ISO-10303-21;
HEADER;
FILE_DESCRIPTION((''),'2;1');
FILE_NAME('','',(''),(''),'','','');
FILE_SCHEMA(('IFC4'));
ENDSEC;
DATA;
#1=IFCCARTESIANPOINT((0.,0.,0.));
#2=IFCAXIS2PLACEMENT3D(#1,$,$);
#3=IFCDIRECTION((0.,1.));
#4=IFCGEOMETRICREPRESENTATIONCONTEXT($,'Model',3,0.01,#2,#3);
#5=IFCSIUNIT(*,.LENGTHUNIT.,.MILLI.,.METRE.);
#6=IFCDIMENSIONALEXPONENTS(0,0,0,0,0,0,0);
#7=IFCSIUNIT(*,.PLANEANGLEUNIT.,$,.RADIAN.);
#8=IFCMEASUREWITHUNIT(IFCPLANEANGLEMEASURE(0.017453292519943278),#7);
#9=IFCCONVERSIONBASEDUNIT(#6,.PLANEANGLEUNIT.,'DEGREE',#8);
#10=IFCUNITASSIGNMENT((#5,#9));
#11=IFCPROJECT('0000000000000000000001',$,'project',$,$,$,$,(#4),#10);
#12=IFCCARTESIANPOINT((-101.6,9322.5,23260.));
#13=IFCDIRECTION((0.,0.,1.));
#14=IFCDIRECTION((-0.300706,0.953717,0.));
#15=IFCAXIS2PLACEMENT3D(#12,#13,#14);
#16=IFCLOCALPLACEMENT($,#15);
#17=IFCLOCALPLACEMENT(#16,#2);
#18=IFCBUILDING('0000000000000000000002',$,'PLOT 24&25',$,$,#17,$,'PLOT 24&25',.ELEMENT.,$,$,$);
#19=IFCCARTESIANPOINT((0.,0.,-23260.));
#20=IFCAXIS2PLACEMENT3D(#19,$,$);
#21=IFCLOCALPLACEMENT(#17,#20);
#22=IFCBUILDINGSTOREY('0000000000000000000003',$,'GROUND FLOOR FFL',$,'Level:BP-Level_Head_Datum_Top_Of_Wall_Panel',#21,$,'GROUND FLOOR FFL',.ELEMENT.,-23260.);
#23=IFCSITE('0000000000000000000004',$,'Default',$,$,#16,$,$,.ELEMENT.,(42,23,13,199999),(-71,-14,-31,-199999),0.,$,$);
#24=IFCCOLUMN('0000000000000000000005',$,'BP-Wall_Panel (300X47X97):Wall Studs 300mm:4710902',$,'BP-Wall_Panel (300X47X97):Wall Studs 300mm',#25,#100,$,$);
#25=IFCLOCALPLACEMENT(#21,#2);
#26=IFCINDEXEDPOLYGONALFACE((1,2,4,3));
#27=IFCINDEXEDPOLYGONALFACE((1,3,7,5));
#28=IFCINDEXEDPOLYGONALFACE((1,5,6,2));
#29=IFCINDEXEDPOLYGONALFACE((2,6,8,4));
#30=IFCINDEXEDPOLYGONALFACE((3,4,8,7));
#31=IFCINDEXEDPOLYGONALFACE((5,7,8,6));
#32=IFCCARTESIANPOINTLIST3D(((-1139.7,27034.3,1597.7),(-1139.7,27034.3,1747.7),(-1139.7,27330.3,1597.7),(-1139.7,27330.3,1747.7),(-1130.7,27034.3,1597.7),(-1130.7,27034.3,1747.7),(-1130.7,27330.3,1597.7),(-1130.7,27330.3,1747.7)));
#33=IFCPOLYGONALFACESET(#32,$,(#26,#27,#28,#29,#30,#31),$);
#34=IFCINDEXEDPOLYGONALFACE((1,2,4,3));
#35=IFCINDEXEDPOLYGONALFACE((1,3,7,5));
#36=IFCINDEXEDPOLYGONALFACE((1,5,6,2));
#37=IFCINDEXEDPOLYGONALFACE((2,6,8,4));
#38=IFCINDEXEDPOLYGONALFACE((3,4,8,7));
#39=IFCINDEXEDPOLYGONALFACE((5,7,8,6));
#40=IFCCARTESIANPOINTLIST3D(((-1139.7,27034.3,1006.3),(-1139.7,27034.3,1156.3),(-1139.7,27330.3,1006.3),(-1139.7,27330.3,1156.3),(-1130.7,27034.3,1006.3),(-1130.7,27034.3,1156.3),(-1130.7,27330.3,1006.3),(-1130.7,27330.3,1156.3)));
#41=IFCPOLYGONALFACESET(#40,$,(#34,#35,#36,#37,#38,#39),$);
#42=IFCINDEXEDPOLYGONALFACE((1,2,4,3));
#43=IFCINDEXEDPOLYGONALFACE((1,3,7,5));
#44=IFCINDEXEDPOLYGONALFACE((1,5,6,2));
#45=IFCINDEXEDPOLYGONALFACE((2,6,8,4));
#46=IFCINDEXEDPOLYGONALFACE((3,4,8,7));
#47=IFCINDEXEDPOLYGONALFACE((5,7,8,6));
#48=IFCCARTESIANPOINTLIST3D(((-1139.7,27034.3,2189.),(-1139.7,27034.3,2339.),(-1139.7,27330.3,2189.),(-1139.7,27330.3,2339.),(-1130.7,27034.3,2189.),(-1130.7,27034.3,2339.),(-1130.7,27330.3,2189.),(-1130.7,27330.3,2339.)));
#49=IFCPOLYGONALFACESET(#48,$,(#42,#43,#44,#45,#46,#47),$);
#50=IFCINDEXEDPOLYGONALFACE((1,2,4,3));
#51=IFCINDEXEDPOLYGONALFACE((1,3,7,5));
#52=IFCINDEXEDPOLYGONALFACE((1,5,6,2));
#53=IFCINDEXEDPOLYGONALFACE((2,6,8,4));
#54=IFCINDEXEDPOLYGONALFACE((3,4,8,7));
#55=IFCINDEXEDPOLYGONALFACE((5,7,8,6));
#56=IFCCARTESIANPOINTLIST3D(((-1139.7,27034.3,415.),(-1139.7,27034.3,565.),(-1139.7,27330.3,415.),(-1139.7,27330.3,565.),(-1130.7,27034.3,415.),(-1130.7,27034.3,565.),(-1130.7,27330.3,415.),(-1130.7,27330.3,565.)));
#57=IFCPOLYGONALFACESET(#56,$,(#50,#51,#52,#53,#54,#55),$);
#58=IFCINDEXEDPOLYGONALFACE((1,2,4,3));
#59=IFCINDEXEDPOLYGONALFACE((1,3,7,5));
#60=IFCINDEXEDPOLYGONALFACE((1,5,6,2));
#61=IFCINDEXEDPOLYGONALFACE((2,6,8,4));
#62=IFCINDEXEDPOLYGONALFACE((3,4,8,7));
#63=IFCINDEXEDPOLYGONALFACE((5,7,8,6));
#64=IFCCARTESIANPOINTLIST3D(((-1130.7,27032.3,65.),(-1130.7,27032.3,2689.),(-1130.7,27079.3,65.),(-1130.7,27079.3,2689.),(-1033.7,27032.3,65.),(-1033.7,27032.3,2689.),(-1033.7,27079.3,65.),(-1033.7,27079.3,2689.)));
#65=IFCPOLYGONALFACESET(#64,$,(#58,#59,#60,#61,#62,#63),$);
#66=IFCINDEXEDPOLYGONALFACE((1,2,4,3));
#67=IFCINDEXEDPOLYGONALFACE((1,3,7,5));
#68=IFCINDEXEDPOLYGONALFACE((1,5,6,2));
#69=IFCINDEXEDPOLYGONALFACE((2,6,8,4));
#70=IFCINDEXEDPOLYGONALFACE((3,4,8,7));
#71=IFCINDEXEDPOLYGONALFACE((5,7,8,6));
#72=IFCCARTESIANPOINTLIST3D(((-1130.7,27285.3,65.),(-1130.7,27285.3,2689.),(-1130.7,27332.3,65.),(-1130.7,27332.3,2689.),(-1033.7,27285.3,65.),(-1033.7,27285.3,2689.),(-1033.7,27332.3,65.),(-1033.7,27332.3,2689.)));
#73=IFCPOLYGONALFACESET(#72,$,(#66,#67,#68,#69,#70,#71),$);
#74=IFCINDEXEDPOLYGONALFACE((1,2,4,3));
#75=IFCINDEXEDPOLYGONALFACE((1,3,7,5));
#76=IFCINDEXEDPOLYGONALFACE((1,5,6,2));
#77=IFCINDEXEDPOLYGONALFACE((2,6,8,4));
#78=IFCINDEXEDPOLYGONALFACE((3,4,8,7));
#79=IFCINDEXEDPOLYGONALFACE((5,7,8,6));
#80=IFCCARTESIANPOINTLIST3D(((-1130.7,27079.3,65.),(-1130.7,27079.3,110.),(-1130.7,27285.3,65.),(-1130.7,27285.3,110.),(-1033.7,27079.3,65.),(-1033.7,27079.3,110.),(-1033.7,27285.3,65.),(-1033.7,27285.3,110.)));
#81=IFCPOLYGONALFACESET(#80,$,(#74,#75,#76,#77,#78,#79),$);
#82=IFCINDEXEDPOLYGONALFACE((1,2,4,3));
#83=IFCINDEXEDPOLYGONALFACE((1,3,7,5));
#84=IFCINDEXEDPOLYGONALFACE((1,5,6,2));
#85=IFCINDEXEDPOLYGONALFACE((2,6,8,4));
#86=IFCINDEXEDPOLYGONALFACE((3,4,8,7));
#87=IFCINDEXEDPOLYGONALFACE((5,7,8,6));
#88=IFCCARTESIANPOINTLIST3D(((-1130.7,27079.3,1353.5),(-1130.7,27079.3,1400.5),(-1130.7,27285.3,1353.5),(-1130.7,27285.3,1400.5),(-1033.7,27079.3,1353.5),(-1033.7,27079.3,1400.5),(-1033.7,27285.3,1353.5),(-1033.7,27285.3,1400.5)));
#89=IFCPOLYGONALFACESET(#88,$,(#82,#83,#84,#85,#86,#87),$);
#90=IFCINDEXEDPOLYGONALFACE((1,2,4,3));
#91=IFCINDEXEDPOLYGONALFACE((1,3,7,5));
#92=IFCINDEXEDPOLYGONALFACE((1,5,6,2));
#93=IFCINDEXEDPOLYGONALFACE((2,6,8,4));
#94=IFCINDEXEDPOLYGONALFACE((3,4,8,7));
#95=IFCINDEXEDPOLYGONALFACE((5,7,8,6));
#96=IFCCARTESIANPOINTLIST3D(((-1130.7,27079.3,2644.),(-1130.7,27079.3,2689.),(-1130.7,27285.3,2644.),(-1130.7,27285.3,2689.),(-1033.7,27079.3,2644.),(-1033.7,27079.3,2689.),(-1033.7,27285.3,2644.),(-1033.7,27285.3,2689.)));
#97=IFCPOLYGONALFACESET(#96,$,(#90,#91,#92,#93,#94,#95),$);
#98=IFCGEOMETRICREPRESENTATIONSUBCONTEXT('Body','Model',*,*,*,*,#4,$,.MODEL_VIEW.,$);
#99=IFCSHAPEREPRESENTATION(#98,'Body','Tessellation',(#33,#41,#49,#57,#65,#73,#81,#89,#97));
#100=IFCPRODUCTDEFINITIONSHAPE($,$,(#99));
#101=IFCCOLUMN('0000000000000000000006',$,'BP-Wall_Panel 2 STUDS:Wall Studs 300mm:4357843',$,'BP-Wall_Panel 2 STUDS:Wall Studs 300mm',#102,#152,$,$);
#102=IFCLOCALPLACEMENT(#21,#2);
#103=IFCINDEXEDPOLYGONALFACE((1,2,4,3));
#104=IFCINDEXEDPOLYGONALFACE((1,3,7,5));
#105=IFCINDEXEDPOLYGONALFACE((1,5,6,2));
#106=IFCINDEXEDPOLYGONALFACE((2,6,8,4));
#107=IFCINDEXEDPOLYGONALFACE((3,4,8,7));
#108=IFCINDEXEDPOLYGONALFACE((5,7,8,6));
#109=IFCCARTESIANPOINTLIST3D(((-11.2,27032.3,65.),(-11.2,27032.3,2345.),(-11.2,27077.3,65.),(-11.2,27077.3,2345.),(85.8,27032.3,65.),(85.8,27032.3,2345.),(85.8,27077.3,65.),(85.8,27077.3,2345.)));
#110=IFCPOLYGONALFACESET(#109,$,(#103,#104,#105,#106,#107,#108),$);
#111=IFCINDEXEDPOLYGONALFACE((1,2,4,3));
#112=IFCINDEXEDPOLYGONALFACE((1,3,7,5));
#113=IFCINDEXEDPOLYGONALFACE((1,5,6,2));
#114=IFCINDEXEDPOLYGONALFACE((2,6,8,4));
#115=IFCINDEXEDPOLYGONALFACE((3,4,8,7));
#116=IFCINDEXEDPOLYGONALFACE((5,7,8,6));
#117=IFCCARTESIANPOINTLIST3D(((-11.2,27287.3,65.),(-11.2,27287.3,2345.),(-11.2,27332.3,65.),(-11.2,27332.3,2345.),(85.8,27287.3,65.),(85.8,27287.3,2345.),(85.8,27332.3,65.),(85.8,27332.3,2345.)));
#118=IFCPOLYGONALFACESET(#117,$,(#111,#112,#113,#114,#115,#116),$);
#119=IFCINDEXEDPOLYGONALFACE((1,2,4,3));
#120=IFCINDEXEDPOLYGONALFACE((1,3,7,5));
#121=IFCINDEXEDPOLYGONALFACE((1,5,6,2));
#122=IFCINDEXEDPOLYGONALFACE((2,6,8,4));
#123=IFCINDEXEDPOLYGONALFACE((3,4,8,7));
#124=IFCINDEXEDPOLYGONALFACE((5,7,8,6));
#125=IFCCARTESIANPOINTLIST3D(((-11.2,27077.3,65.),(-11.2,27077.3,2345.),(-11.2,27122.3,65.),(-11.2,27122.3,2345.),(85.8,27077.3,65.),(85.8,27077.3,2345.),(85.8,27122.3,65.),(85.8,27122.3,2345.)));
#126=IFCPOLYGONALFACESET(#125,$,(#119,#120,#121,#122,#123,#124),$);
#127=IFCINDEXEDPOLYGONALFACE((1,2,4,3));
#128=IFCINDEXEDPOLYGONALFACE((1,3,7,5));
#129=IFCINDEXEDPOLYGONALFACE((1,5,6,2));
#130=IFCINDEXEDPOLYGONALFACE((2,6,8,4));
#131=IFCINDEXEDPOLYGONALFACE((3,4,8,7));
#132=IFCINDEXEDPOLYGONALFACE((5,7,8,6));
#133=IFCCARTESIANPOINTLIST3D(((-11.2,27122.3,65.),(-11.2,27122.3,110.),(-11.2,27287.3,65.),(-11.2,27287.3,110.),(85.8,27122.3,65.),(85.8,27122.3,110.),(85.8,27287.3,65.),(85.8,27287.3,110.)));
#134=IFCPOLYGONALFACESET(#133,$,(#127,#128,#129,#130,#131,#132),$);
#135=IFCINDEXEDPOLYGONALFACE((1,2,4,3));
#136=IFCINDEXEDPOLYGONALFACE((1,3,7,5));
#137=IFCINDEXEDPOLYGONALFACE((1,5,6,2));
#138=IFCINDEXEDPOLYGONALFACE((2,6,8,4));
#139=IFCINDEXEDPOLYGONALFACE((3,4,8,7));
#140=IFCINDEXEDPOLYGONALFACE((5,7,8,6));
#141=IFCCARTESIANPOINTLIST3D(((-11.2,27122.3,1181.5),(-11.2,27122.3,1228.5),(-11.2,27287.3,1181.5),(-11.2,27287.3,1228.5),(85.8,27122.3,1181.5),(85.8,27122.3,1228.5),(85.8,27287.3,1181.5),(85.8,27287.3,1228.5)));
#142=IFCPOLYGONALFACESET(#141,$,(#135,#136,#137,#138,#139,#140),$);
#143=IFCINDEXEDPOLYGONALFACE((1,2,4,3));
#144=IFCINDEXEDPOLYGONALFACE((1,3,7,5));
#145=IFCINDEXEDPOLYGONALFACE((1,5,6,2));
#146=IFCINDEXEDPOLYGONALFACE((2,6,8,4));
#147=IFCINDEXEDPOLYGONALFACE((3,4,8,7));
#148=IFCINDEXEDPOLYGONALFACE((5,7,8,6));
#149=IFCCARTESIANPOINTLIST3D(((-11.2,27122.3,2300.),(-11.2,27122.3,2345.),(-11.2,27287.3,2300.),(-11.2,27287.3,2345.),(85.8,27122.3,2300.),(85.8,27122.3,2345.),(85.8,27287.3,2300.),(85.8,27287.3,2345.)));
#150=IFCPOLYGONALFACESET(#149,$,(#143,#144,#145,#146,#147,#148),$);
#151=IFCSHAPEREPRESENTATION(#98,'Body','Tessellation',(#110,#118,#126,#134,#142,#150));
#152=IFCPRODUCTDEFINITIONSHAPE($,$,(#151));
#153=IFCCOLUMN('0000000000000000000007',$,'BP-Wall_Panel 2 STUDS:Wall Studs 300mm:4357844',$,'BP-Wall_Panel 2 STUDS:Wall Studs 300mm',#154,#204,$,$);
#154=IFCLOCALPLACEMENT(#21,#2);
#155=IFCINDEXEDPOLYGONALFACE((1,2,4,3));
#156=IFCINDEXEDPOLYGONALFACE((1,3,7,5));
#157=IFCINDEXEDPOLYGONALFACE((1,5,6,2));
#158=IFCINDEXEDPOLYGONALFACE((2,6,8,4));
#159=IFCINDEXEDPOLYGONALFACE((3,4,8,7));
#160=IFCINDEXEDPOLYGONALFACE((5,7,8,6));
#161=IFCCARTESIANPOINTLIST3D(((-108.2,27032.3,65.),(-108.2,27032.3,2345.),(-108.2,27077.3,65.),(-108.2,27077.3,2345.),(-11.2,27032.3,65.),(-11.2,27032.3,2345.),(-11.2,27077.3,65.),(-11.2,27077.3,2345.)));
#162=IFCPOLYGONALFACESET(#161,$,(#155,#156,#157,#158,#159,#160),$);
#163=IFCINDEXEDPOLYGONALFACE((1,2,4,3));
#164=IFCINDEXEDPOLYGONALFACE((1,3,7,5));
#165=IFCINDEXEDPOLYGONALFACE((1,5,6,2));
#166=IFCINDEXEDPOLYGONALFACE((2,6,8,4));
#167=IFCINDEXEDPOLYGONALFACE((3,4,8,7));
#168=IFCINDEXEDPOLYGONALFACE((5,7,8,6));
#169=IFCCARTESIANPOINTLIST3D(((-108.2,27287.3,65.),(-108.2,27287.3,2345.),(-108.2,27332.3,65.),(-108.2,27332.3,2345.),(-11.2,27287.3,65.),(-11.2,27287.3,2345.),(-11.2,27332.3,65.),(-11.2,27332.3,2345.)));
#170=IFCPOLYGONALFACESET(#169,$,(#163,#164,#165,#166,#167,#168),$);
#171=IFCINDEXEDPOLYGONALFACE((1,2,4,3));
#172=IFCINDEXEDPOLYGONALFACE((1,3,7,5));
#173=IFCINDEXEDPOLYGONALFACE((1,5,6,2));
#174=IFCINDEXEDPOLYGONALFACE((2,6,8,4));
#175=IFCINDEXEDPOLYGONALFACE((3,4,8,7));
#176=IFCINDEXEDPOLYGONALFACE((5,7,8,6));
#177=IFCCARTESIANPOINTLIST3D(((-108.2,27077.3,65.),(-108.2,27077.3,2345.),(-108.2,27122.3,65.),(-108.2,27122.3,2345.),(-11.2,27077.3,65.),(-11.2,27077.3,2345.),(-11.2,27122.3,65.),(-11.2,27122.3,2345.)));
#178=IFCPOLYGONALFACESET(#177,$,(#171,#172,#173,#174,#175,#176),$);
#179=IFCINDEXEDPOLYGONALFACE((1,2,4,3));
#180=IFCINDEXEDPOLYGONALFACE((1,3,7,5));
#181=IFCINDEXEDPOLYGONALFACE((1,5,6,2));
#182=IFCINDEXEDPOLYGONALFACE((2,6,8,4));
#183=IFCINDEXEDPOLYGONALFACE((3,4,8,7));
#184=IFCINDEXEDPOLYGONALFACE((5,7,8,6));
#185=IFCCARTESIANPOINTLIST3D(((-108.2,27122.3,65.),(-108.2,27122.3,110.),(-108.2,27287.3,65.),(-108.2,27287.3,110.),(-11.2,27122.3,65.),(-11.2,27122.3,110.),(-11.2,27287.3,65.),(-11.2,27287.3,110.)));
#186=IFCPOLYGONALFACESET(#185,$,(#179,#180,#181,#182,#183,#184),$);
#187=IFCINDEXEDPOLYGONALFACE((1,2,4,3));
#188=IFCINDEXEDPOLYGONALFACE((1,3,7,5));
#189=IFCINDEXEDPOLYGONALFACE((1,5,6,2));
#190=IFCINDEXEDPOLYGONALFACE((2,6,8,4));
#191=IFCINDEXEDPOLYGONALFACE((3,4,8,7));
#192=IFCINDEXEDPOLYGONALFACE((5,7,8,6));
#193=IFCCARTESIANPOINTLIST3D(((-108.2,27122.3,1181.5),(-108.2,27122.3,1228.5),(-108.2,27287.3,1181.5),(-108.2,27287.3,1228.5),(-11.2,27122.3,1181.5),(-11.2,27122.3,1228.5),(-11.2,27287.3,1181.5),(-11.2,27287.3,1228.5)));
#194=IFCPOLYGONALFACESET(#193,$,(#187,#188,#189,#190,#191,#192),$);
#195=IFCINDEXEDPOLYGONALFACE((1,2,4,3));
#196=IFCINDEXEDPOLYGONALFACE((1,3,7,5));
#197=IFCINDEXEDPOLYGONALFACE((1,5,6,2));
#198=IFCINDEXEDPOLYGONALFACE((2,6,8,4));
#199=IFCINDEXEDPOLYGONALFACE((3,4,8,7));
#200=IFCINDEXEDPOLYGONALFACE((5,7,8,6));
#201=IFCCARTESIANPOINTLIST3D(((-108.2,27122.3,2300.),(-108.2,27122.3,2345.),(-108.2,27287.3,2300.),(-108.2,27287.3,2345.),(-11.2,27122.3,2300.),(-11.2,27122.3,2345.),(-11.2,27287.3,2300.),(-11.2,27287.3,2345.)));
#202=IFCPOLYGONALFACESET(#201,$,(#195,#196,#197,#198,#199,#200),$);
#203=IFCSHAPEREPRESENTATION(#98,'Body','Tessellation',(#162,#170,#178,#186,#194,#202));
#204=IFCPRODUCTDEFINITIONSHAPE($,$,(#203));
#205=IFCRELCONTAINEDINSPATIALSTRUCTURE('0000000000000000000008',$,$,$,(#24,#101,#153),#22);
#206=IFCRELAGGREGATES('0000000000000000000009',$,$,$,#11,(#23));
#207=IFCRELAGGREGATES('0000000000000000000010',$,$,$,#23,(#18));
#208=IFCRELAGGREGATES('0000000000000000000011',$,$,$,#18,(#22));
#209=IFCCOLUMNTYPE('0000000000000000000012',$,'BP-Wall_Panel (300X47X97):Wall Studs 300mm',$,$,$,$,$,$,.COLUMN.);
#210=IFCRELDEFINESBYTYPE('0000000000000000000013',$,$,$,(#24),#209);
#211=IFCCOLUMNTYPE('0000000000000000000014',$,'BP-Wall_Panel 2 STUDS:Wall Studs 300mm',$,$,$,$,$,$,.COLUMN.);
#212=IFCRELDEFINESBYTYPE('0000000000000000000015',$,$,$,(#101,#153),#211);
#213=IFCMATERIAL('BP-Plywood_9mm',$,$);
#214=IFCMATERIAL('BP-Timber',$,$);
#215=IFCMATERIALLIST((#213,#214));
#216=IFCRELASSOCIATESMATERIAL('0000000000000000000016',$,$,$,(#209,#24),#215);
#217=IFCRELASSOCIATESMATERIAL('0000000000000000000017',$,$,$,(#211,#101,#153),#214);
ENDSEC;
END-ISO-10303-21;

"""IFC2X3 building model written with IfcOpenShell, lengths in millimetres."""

from ifc_helpers import new_model, entity, si_unit, converted_unit, direction, frame, frame_2d, origin, origin_2d_with_axis, place, context, subcontext, project, spatial, rectangle, extrude, source, transform, mapped, material, material_list, type_object, type_shapes, element, save


model = new_model("IFC2X3")

# Units and contexts
model_context = context("Model", 3, precision=0.01, world=origin(), true_north=direction((0.0, 1.0)))
body_context = subcontext(model_context, "Body", "Model", "MODEL_VIEW")
ifc_project = project(units=[si_unit("LENGTHUNIT", "METRE", prefix="MILLI"), converted_unit("PLANEANGLEUNIT", "DEGREE", entity("IfcPlaneAngleMeasure", 0.017453292519943278), si_unit("PLANEANGLEUNIT", "RADIAN"), dimensions=[0, 0, 0, 0, 0, 0, 0])], contexts=[model_context])

# Site, building, storey
site_placement = place(None, frame((-101.6, 9322.5, 23260.0), z_axis=(0.0, 0.0, 1.0), x_axis=(-0.300706, 0.953717, 0.0)))
site = spatial("IfcSite", under=ifc_project, at=site_placement, Name="Default", CompositionType="ELEMENT", RefLatitude=(42, 23, 13, 199999), RefLongitude=(-71, -14, -31, -199999), RefElevation=0.0)
building_placement = place(site_placement, origin())
building = spatial("IfcBuilding", under=site, at=building_placement, Name="PLOT 24&25", LongName="PLOT 24&25", CompositionType="ELEMENT")
storey_placement = place(building_placement, frame((0.0, 0.0, -23260.0)))
storey = spatial("IfcBuildingStorey", under=building, at=storey_placement, Name="GROUND FLOOR FFL", ObjectType="Level:BP-Level_Head_Datum_Top_Of_Wall_Panel", LongName="GROUND FLOOR FFL", CompositionType="ELEMENT", Elevation=-23260.0)

# Columns
ifc_material_1 = material(Name="BP-Plywood_9mm")
ifc_material_2 = material(Name="BP-Timber")
ifc_material_list = material_list([ifc_material_1, ifc_material_2])
column_type_1 = type_object("IfcColumnType", Name="BP-Wall_Panel (300X47X97):Wall Studs 300mm", PredefinedType="COLUMN", material=ifc_material_list)
shared_shape_1 = source(origin(), body_context, "Body", "SweptSolid", [
    extrude(rectangle(XDim=9.0, YDim=296.0, at=origin_2d_with_axis()), frame((-53.0, 0.0, -21662.3), z_axis=(0.0, 0.0, 1.0), x_axis=(-1.0, 0.0, 0.0)), (0.0, 0.0, 1.0), 150.0),
    extrude(rectangle(XDim=9.0, YDim=296.0, at=origin_2d_with_axis()), frame((-53.0, 0.0, -22253.7), z_axis=(0.0, 0.0, 1.0), x_axis=(-1.0, 0.0, 0.0)), (0.0, 0.0, 1.0), 150.0),
    extrude(rectangle(XDim=9.0, YDim=296.0, at=origin_2d_with_axis()), frame((-53.0, 0.0, -21071.0), z_axis=(0.0, 0.0, 1.0), x_axis=(-1.0, 0.0, 0.0)), (0.0, 0.0, 1.0), 150.0),
    extrude(rectangle(XDim=9.0, YDim=296.0, at=origin_2d_with_axis()), frame((-53.0, 0.0, -22845.0), z_axis=(0.0, 0.0, 1.0), x_axis=(-1.0, 0.0, 0.0)), (0.0, 0.0, 1.0), 150.0),
    extrude(rectangle(XDim=97.0, YDim=47.0, at=origin_2d_with_axis()), frame((0.0, -126.5, -23195.0), z_axis=(0.0, 0.0, 1.0), x_axis=(-1.0, 0.0, 0.0)), (0.0, 0.0, 1.0), 2624.0),
    extrude(rectangle(XDim=97.0, YDim=47.0, at=frame_2d((0.0, 0.0), x_axis=(1.0, 0.0))), frame((0.0, 126.5, -23195.0), z_axis=(0.0, 0.0, 1.0), x_axis=(-1.0, 0.0, 0.0)), (0.0, 0.0, 1.0), 2624.0),
    extrude(rectangle(XDim=206.0, YDim=97.0, at=origin_2d_with_axis()), frame((0.0, 0.0, -23195.0), z_axis=(0.0, 0.0, 1.0), x_axis=(0.0, -1.0, 0.0)), (0.0, 0.0, 1.0), 45.0),
    extrude(rectangle(XDim=206.0, YDim=97.0, at=origin_2d_with_axis()), frame((0.0, 0.0, -21906.5), z_axis=(0.0, 0.0, 1.0), x_axis=(0.0, -1.0, 0.0)), (0.0, 0.0, 1.0), 47.0),
    extrude(rectangle(XDim=206.0, YDim=97.0, at=origin_2d_with_axis()), frame((0.0, 0.0, -20616.0), z_axis=(0.0, 0.0, 1.0), x_axis=(0.0, -1.0, 0.0)), (0.0, 0.0, 1.0), 45.0),
])
type_shapes(column_type_1, [shared_shape_1])
for number, where, name in (
    (1, (-1082.2, 27182.3, 23260.0), "BP-Wall_Panel (300X47X97):Wall Studs 300mm:4710902"),
):
    element("IfcColumn", number, at=place(storey_placement, frame(where)), inside=storey, type_object=column_type_1, material=ifc_material_list, Name=name, ObjectType="BP-Wall_Panel (300X47X97):Wall Studs 300mm", context=body_context, shape_type="MappedRepresentation", body=[
        mapped(shared_shape_1, transform((0.0, 0.0, 0.0), scale=1.0)),
    ])
column_type_2 = type_object("IfcColumnType", Name="BP-Wall_Panel 2 STUDS:Wall Studs 300mm", PredefinedType="COLUMN", material=ifc_material_2)
shared_shape_2 = source(origin(), body_context, "Body", "SweptSolid", [
    extrude(rectangle(XDim=97.0, YDim=45.0, at=origin_2d_with_axis()), frame((0.0, -127.5, -23195.0), z_axis=(0.0, 0.0, 1.0), x_axis=(-1.0, 0.0, 0.0)), (0.0, 0.0, 1.0), 2280.0),
    extrude(rectangle(XDim=97.0, YDim=45.0, at=frame_2d((0.0, 0.0), x_axis=(1.0, 0.0))), frame((0.0, 127.5, -23195.0), z_axis=(0.0, 0.0, 1.0), x_axis=(-1.0, 0.0, 0.0)), (0.0, 0.0, 1.0), 2280.0),
    extrude(rectangle(XDim=97.0, YDim=45.0, at=frame_2d((0.0, 0.0), x_axis=(1.0, 0.0))), frame((0.0, -82.5, -23195.0), z_axis=(0.0, 0.0, 1.0), x_axis=(-1.0, 0.0, 0.0)), (0.0, 0.0, 1.0), 2280.0),
    extrude(rectangle(XDim=165.0, YDim=97.0, at=origin_2d_with_axis()), frame((0.0, 22.5, -23195.0), z_axis=(0.0, 0.0, 1.0), x_axis=(0.0, -1.0, 0.0)), (0.0, 0.0, 1.0), 45.0),
    extrude(rectangle(XDim=165.0, YDim=97.0, at=frame_2d((0.0, 0.0), x_axis=(1.0, 0.0))), frame((0.0, 22.5, -22078.5), z_axis=(0.0, 0.0, 1.0), x_axis=(0.0, -1.0, 0.0)), (0.0, 0.0, 1.0), 47.0),
    extrude(rectangle(XDim=165.0, YDim=97.0, at=origin_2d_with_axis()), frame((0.0, 22.5, -20960.0), z_axis=(0.0, 0.0, 1.0), x_axis=(0.0, -1.0, 0.0)), (0.0, 0.0, 1.0), 45.0),
])
type_shapes(column_type_2, [shared_shape_2])
for number, where, name in (
    (2, (37.3, 27182.3, 23260.0), "BP-Wall_Panel 2 STUDS:Wall Studs 300mm:4357843"),
    (3, (-59.7, 27182.3, 23260.0), "BP-Wall_Panel 2 STUDS:Wall Studs 300mm:4357844"),
):
    element("IfcColumn", number, at=place(storey_placement, frame(where)), inside=storey, type_object=column_type_2, material=ifc_material_2, Name=name, ObjectType="BP-Wall_Panel 2 STUDS:Wall Studs 300mm", context=body_context, shape_type="MappedRepresentation", body=[
        mapped(shared_shape_2, transform((0.0, 0.0, 0.0), scale=1.0)),
    ])

save(model, "model.ifc")
